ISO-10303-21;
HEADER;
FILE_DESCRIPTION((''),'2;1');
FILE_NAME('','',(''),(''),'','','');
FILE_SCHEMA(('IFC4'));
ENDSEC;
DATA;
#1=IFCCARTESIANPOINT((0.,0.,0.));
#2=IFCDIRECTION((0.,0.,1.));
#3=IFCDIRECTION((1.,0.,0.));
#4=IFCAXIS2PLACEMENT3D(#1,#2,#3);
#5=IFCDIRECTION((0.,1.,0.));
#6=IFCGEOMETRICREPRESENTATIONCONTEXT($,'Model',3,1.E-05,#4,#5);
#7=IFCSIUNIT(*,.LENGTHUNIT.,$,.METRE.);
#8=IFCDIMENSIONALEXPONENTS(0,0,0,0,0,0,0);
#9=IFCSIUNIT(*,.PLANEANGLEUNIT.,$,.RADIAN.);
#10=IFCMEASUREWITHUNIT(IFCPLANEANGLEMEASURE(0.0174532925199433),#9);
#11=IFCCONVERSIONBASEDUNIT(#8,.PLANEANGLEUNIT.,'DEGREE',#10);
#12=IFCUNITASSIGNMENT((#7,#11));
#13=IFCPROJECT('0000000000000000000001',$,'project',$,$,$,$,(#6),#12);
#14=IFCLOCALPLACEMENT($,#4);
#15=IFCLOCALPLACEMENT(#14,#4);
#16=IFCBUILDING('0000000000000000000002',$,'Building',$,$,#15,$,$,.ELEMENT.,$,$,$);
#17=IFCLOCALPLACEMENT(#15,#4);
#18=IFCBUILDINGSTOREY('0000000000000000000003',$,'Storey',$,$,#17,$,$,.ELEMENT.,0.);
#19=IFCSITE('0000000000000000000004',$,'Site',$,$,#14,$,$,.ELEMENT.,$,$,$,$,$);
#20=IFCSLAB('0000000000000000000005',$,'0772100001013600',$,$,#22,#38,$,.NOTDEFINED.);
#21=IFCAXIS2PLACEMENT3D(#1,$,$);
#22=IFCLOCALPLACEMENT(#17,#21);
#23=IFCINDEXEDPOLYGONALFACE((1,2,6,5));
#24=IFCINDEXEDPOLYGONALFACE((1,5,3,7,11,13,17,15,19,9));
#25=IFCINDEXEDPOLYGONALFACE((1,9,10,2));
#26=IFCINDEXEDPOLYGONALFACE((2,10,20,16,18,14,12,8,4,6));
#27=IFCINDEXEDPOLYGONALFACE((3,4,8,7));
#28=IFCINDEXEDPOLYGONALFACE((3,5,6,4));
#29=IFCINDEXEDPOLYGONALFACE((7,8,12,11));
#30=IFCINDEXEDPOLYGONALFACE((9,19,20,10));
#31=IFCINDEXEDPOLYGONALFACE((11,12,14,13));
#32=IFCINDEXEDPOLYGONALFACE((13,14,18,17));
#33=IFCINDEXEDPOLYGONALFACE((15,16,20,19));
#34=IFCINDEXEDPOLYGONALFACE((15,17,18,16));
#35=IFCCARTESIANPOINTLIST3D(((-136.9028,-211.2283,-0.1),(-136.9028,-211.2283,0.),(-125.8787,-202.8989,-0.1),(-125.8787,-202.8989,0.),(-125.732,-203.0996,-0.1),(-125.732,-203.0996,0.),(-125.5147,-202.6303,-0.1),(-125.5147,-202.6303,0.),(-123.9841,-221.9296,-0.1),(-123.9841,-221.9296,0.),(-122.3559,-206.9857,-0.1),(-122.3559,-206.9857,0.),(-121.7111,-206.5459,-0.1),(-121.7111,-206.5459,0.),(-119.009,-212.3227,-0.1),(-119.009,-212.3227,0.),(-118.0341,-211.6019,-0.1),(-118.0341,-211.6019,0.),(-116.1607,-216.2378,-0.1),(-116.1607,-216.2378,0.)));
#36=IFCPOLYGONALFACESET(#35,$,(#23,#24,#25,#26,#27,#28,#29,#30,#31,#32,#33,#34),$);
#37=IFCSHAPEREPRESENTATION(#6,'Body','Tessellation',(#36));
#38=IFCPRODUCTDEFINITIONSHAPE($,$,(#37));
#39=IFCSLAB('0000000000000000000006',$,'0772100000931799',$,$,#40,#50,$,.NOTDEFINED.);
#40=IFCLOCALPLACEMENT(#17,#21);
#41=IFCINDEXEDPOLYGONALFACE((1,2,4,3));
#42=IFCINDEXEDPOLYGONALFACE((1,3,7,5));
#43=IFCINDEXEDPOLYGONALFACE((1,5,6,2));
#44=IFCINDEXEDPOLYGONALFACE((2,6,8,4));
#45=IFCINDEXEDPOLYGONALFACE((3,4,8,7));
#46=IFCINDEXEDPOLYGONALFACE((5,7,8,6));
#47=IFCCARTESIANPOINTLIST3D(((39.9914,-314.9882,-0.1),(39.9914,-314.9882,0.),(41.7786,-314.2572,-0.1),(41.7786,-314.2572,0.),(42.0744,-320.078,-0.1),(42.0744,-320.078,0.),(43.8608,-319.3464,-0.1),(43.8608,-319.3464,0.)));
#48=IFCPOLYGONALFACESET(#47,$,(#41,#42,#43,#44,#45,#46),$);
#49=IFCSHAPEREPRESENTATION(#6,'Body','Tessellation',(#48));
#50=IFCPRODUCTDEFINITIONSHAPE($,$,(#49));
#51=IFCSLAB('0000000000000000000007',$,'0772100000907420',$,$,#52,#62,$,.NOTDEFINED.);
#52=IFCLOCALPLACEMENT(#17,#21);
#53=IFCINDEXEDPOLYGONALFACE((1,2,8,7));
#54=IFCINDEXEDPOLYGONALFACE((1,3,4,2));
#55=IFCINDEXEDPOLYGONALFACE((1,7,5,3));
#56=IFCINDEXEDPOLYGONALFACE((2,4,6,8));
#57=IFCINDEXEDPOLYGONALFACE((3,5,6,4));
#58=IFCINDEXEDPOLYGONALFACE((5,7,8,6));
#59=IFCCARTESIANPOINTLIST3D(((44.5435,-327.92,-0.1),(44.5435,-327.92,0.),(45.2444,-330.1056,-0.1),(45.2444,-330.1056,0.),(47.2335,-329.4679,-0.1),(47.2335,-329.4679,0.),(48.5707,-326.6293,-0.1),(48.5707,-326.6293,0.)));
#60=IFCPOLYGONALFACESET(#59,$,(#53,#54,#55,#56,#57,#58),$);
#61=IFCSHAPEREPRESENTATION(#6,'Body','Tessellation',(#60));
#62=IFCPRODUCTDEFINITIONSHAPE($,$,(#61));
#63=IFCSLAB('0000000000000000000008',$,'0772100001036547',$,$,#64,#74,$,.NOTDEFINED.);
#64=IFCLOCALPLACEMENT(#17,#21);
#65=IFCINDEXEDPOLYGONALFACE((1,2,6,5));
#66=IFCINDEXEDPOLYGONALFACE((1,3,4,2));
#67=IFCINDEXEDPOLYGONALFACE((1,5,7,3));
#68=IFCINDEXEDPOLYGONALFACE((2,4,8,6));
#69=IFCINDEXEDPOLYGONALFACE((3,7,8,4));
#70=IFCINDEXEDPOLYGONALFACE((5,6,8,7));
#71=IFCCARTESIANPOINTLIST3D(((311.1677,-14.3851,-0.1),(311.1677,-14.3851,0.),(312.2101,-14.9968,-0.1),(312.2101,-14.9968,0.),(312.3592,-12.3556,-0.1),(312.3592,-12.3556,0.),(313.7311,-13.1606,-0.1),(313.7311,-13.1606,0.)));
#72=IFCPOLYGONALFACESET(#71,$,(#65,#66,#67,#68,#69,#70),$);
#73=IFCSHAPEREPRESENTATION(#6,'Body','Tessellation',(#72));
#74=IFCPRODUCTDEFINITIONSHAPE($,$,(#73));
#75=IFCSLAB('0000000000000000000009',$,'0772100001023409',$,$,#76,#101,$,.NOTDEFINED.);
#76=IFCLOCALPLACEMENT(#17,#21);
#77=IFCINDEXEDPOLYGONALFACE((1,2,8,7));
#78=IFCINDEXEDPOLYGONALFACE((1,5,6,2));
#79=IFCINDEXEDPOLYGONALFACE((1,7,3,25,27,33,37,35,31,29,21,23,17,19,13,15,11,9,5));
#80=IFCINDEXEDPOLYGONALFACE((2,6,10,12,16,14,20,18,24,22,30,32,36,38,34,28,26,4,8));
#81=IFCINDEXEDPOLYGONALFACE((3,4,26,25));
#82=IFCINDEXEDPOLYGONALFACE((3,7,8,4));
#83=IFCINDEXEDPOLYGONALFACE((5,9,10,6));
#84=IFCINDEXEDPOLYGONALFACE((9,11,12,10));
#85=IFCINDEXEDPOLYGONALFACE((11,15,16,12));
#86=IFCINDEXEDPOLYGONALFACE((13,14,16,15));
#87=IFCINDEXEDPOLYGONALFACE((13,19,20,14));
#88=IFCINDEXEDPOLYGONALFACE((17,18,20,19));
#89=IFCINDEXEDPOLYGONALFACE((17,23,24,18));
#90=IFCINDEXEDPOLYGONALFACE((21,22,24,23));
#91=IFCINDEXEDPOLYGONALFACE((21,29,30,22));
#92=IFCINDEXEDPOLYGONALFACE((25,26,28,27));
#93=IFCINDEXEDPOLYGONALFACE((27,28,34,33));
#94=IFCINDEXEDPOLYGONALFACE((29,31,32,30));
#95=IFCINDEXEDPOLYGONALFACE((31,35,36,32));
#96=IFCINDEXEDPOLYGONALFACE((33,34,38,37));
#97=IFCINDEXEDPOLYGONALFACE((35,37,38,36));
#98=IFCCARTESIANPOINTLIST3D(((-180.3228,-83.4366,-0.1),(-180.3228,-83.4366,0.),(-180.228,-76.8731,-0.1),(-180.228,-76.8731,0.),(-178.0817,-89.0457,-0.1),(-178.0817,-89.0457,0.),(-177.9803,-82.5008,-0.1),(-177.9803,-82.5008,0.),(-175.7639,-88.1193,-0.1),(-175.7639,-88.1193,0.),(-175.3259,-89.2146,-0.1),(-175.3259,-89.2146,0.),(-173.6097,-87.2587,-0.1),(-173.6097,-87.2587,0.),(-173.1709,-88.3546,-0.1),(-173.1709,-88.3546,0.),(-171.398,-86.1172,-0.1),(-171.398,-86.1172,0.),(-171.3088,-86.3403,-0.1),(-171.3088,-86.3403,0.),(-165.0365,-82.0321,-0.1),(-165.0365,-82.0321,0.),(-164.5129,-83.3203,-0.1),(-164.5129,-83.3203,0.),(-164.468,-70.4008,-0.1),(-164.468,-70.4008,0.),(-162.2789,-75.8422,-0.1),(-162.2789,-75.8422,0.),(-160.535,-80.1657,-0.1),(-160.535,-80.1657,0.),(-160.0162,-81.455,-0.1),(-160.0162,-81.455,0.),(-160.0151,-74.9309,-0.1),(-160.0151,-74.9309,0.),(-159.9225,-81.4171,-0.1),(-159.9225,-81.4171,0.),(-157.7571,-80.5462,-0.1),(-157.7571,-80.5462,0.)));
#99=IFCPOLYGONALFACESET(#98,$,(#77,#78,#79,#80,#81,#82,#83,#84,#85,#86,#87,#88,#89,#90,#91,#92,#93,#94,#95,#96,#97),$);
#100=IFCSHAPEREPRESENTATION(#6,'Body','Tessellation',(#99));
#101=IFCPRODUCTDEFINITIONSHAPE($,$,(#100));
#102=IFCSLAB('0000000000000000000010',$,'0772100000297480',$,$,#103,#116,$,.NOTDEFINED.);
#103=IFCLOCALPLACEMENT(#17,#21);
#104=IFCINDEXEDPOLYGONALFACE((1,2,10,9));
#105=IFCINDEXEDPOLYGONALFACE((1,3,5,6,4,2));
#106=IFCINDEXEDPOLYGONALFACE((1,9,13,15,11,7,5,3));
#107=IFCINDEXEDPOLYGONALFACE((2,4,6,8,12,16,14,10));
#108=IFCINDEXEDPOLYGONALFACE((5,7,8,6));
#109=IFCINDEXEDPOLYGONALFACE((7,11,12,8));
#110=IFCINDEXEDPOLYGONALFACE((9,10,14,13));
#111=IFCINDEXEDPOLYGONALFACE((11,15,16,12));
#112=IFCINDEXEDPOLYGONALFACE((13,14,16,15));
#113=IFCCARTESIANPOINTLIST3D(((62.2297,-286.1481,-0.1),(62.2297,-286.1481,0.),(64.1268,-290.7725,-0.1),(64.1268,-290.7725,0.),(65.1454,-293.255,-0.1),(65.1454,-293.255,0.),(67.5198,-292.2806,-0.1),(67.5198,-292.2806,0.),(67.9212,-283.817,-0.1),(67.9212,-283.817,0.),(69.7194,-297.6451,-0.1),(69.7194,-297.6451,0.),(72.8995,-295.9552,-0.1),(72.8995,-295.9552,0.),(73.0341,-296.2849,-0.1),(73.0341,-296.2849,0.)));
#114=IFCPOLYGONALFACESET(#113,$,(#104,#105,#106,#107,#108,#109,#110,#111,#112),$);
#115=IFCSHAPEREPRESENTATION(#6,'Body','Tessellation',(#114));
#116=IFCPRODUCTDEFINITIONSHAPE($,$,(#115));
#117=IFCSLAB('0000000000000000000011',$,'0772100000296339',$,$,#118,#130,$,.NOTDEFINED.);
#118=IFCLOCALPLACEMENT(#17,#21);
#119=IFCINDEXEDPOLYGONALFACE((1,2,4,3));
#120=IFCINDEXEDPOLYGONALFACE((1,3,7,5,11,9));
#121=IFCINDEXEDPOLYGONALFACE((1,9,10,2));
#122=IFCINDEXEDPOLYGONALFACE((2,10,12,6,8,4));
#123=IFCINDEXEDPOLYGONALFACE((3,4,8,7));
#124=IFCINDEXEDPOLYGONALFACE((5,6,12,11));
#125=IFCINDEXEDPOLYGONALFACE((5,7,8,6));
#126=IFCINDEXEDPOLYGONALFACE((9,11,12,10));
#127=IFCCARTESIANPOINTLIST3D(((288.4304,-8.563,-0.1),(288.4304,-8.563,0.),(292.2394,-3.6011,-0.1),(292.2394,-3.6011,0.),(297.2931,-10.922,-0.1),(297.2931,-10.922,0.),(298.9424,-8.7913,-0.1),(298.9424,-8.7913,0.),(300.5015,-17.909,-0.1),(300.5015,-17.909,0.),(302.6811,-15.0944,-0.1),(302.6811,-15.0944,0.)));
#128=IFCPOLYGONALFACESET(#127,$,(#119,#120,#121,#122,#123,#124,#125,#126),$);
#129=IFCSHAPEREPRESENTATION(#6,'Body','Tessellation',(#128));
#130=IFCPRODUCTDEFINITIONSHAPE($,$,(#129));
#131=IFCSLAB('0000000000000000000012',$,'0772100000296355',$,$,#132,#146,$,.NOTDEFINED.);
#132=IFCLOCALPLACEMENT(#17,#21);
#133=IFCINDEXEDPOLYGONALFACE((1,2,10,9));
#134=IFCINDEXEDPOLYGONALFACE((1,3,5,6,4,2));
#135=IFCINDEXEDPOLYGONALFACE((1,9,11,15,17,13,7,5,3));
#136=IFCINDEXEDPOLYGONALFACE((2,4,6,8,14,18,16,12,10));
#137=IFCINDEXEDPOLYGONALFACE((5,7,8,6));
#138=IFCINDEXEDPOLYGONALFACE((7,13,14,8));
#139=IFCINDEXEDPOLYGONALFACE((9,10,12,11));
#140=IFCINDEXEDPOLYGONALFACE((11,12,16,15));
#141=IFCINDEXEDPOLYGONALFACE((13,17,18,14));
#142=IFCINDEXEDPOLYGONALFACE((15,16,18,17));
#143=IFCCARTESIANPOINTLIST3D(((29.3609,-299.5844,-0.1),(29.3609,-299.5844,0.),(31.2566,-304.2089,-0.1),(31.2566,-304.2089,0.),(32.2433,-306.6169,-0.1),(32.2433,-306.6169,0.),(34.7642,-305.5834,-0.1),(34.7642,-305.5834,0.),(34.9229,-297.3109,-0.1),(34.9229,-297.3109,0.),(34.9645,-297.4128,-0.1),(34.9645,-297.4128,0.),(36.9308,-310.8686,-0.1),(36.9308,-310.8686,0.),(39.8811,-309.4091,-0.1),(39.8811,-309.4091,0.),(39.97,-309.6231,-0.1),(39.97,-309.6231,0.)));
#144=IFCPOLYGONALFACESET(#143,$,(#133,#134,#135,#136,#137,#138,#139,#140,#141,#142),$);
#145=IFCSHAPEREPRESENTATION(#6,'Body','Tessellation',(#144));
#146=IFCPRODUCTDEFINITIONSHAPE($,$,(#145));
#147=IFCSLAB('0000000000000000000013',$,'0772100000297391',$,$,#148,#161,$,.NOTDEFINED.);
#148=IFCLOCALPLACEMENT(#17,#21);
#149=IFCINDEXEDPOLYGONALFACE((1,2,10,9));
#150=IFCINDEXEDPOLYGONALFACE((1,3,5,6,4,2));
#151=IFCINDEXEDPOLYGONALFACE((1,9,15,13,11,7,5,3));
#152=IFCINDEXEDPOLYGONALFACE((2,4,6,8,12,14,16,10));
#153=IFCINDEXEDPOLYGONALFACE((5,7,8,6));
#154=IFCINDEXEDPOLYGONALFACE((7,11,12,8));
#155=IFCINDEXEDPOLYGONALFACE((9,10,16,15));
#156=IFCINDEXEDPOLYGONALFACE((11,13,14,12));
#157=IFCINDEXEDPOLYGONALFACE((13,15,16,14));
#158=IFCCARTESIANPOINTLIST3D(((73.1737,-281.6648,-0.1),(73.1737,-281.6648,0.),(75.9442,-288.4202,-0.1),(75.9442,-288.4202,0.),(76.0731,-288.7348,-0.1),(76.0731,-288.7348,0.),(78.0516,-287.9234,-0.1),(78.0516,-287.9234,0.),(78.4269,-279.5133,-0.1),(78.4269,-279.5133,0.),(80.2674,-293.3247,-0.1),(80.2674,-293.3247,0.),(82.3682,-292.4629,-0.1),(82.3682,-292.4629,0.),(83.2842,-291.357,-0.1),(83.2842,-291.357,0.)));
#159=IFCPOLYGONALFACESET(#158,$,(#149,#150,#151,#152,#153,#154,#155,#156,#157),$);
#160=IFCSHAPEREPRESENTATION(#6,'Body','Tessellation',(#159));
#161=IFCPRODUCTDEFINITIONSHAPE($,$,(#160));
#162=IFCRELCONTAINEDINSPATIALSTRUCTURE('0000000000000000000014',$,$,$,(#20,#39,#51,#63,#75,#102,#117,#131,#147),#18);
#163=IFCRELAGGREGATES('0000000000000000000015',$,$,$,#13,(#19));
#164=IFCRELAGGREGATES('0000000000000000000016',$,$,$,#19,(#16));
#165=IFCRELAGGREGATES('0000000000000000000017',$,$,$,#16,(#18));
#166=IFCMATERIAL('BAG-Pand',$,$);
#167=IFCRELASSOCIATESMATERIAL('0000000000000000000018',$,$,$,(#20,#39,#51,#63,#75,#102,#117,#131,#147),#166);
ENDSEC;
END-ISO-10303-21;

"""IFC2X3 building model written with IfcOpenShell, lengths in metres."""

from ifc_helpers import new_model, entity, si_unit, converted_unit, direction, frame, origin_with_axes, place, context, project, spatial, polyline, outline, extrude, material, element, save


model = new_model("IFC2X3")

# Units and contexts
model_context = context("Model", 3, precision=1e-05, world=origin_with_axes(), true_north=direction((0.0, 1.0, 0.0)))
ifc_project = project(units=[si_unit("LENGTHUNIT", "METRE"), converted_unit("PLANEANGLEUNIT", "DEGREE", entity("IfcPlaneAngleMeasure", 0.0174532925199433), si_unit("PLANEANGLEUNIT", "RADIAN"), dimensions=[0, 0, 0, 0, 0, 0, 0])], contexts=[model_context])

# Site, building, storey
site_placement = place(None, origin_with_axes())
site = spatial("IfcSite", under=ifc_project, at=site_placement, Name="Site", CompositionType="ELEMENT")
building_placement = place(site_placement, origin_with_axes())
building = spatial("IfcBuilding", under=site, at=building_placement, Name="Building", CompositionType="ELEMENT")
storey_placement = place(building_placement, origin_with_axes())
storey = spatial("IfcBuildingStorey", under=building, at=storey_placement, Name="Storey", CompositionType="ELEMENT", Elevation=0.0)

# Slabs
ifc_material = material(Name="BAG-Pand")
slab_1_placement = place(storey_placement, frame((0.0, 0.0, -0.1), z_axis=(0.0, 0.0, 1.0), x_axis=(1.0, 0.0, 0.0)))
element("IfcSlab", 1, at=slab_1_placement, inside=storey, material=ifc_material, Name="0772100001013600", PredefinedType="NOTDEFINED", context=model_context, shape_type="SweptSolid", body=[
    extrude(outline(polyline([(-125.732, -203.0996), (-125.8787, -202.8989), (-125.5147, -202.6303), (-122.3559, -206.9857), (-121.7111, -206.5459), (-118.0341, -211.6019), (-119.009, -212.3227), (-116.1607, -216.2378), (-123.9841, -221.9296), (-136.9028, -211.2283), (-125.732, -203.0996)])), origin_with_axes(), (0.0, 0.0, 1.0), 0.1),
])
slab_2_placement = place(storey_placement, frame((0.0, 0.0, -0.1), z_axis=(0.0, 0.0, 1.0), x_axis=(1.0, 0.0, 0.0)))
element("IfcSlab", 2, at=slab_2_placement, inside=storey, material=ifc_material, Name="0772100000931799", PredefinedType="NOTDEFINED", context=model_context, shape_type="SweptSolid", body=[
    extrude(outline(polyline([(39.9914, -314.9882), (41.7786, -314.2572), (43.8608, -319.3464), (42.0744, -320.078), (39.9914, -314.9882)])), origin_with_axes(), (0.0, 0.0, 1.0), 0.1),
])
slab_3_placement = place(storey_placement, frame((0.0, 0.0, -0.1), z_axis=(0.0, 0.0, 1.0), x_axis=(1.0, 0.0, 0.0)))
element("IfcSlab", 3, at=slab_3_placement, inside=storey, material=ifc_material, Name="0772100000907420", PredefinedType="NOTDEFINED", context=model_context, shape_type="SweptSolid", body=[
    extrude(outline(polyline([(44.5435, -327.92), (48.5707, -326.6293), (47.2335, -329.4679), (45.2444, -330.1056), (44.5435, -327.92)])), origin_with_axes(), (0.0, 0.0, 1.0), 0.1),
])
slab_4_placement = place(storey_placement, frame((0.0, 0.0, -0.1), z_axis=(0.0, 0.0, 1.0), x_axis=(1.0, 0.0, 0.0)))
element("IfcSlab", 4, at=slab_4_placement, inside=storey, material=ifc_material, Name="0772100001036547", PredefinedType="NOTDEFINED", context=model_context, shape_type="SweptSolid", body=[
    extrude(outline(polyline([(311.1677, -14.3851), (312.3592, -12.3556), (313.7311, -13.1606), (312.2101, -14.9968), (311.1677, -14.3851)])), origin_with_axes(), (0.0, 0.0, 1.0), 0.1),
])
slab_5_placement = place(storey_placement, frame((0.0, 0.0, -0.1), z_axis=(0.0, 0.0, 1.0), x_axis=(1.0, 0.0, 0.0)))
element("IfcSlab", 5, at=slab_5_placement, inside=storey, material=ifc_material, Name="0772100001023409", PredefinedType="NOTDEFINED", context=model_context, shape_type="SweptSolid", body=[
    extrude(outline(polyline([(-180.3228, -83.4366), (-177.9803, -82.5008), (-180.228, -76.8731), (-164.468, -70.4008), (-162.2789, -75.8422), (-160.0151, -74.9309), (-157.7571, -80.5462), (-159.9225, -81.4171), (-160.0162, -81.455), (-160.535, -80.1657), (-165.0365, -82.0321), (-164.5129, -83.3203), (-171.398, -86.1172), (-171.3088, -86.3403), (-173.6097, -87.2587), (-173.1709, -88.3546), (-175.3259, -89.2146), (-175.7639, -88.1193), (-178.0817, -89.0457), (-180.3228, -83.4366)])), origin_with_axes(), (0.0, 0.0, 1.0), 0.1),
])
slab_6_placement = place(storey_placement, frame((0.0, 0.0, -0.1), z_axis=(0.0, 0.0, 1.0), x_axis=(1.0, 0.0, 0.0)))
element("IfcSlab", 6, at=slab_6_placement, inside=storey, material=ifc_material, Name="0772100000297480", PredefinedType="NOTDEFINED", context=model_context, shape_type="SweptSolid", body=[
    extrude(outline(polyline([(67.9212, -283.817), (72.8995, -295.9552), (73.0341, -296.2849), (69.7194, -297.6451), (67.5198, -292.2806), (65.1454, -293.255), (64.1268, -290.7725), (62.2297, -286.1481), (67.9212, -283.817)])), origin_with_axes(), (0.0, 0.0, 1.0), 0.1),
])
slab_7_placement = place(storey_placement, frame((0.0, 0.0, -0.1), z_axis=(0.0, 0.0, 1.0), x_axis=(1.0, 0.0, 0.0)))
element("IfcSlab", 7, at=slab_7_placement, inside=storey, material=ifc_material, Name="0772100000296339", PredefinedType="NOTDEFINED", context=model_context, shape_type="SweptSolid", body=[
    extrude(outline(polyline([(292.2394, -3.6011), (298.9424, -8.7913), (297.2931, -10.922), (302.6811, -15.0944), (300.5015, -17.909), (288.4304, -8.563), (292.2394, -3.6011)])), origin_with_axes(), (0.0, 0.0, 1.0), 0.1),
])
slab_8_placement = place(storey_placement, frame((0.0, 0.0, -0.1), z_axis=(0.0, 0.0, 1.0), x_axis=(1.0, 0.0, 0.0)))
element("IfcSlab", 8, at=slab_8_placement, inside=storey, material=ifc_material, Name="0772100000296355", PredefinedType="NOTDEFINED", context=model_context, shape_type="SweptSolid", body=[
    extrude(outline(polyline([(34.9229, -297.3109), (34.9645, -297.4128), (39.8811, -309.4091), (39.97, -309.6231), (36.9308, -310.8686), (34.7642, -305.5834), (32.2433, -306.6169), (31.2566, -304.2089), (29.3609, -299.5844), (34.9229, -297.3109)])), origin_with_axes(), (0.0, 0.0, 1.0), 0.1),
])
slab_9_placement = place(storey_placement, frame((0.0, 0.0, -0.1), z_axis=(0.0, 0.0, 1.0), x_axis=(1.0, 0.0, 0.0)))
element("IfcSlab", 9, at=slab_9_placement, inside=storey, material=ifc_material, Name="0772100000297391", PredefinedType="NOTDEFINED", context=model_context, shape_type="SweptSolid", body=[
    extrude(outline(polyline([(80.2674, -293.3247), (78.0516, -287.9234), (76.0731, -288.7348), (75.9442, -288.4202), (73.1737, -281.6648), (78.4269, -279.5133), (83.2842, -291.357), (82.3682, -292.4629), (80.2674, -293.3247)])), origin_with_axes(), (0.0, 0.0, 1.0), 0.1),
])

save(model, "model.ifc")
